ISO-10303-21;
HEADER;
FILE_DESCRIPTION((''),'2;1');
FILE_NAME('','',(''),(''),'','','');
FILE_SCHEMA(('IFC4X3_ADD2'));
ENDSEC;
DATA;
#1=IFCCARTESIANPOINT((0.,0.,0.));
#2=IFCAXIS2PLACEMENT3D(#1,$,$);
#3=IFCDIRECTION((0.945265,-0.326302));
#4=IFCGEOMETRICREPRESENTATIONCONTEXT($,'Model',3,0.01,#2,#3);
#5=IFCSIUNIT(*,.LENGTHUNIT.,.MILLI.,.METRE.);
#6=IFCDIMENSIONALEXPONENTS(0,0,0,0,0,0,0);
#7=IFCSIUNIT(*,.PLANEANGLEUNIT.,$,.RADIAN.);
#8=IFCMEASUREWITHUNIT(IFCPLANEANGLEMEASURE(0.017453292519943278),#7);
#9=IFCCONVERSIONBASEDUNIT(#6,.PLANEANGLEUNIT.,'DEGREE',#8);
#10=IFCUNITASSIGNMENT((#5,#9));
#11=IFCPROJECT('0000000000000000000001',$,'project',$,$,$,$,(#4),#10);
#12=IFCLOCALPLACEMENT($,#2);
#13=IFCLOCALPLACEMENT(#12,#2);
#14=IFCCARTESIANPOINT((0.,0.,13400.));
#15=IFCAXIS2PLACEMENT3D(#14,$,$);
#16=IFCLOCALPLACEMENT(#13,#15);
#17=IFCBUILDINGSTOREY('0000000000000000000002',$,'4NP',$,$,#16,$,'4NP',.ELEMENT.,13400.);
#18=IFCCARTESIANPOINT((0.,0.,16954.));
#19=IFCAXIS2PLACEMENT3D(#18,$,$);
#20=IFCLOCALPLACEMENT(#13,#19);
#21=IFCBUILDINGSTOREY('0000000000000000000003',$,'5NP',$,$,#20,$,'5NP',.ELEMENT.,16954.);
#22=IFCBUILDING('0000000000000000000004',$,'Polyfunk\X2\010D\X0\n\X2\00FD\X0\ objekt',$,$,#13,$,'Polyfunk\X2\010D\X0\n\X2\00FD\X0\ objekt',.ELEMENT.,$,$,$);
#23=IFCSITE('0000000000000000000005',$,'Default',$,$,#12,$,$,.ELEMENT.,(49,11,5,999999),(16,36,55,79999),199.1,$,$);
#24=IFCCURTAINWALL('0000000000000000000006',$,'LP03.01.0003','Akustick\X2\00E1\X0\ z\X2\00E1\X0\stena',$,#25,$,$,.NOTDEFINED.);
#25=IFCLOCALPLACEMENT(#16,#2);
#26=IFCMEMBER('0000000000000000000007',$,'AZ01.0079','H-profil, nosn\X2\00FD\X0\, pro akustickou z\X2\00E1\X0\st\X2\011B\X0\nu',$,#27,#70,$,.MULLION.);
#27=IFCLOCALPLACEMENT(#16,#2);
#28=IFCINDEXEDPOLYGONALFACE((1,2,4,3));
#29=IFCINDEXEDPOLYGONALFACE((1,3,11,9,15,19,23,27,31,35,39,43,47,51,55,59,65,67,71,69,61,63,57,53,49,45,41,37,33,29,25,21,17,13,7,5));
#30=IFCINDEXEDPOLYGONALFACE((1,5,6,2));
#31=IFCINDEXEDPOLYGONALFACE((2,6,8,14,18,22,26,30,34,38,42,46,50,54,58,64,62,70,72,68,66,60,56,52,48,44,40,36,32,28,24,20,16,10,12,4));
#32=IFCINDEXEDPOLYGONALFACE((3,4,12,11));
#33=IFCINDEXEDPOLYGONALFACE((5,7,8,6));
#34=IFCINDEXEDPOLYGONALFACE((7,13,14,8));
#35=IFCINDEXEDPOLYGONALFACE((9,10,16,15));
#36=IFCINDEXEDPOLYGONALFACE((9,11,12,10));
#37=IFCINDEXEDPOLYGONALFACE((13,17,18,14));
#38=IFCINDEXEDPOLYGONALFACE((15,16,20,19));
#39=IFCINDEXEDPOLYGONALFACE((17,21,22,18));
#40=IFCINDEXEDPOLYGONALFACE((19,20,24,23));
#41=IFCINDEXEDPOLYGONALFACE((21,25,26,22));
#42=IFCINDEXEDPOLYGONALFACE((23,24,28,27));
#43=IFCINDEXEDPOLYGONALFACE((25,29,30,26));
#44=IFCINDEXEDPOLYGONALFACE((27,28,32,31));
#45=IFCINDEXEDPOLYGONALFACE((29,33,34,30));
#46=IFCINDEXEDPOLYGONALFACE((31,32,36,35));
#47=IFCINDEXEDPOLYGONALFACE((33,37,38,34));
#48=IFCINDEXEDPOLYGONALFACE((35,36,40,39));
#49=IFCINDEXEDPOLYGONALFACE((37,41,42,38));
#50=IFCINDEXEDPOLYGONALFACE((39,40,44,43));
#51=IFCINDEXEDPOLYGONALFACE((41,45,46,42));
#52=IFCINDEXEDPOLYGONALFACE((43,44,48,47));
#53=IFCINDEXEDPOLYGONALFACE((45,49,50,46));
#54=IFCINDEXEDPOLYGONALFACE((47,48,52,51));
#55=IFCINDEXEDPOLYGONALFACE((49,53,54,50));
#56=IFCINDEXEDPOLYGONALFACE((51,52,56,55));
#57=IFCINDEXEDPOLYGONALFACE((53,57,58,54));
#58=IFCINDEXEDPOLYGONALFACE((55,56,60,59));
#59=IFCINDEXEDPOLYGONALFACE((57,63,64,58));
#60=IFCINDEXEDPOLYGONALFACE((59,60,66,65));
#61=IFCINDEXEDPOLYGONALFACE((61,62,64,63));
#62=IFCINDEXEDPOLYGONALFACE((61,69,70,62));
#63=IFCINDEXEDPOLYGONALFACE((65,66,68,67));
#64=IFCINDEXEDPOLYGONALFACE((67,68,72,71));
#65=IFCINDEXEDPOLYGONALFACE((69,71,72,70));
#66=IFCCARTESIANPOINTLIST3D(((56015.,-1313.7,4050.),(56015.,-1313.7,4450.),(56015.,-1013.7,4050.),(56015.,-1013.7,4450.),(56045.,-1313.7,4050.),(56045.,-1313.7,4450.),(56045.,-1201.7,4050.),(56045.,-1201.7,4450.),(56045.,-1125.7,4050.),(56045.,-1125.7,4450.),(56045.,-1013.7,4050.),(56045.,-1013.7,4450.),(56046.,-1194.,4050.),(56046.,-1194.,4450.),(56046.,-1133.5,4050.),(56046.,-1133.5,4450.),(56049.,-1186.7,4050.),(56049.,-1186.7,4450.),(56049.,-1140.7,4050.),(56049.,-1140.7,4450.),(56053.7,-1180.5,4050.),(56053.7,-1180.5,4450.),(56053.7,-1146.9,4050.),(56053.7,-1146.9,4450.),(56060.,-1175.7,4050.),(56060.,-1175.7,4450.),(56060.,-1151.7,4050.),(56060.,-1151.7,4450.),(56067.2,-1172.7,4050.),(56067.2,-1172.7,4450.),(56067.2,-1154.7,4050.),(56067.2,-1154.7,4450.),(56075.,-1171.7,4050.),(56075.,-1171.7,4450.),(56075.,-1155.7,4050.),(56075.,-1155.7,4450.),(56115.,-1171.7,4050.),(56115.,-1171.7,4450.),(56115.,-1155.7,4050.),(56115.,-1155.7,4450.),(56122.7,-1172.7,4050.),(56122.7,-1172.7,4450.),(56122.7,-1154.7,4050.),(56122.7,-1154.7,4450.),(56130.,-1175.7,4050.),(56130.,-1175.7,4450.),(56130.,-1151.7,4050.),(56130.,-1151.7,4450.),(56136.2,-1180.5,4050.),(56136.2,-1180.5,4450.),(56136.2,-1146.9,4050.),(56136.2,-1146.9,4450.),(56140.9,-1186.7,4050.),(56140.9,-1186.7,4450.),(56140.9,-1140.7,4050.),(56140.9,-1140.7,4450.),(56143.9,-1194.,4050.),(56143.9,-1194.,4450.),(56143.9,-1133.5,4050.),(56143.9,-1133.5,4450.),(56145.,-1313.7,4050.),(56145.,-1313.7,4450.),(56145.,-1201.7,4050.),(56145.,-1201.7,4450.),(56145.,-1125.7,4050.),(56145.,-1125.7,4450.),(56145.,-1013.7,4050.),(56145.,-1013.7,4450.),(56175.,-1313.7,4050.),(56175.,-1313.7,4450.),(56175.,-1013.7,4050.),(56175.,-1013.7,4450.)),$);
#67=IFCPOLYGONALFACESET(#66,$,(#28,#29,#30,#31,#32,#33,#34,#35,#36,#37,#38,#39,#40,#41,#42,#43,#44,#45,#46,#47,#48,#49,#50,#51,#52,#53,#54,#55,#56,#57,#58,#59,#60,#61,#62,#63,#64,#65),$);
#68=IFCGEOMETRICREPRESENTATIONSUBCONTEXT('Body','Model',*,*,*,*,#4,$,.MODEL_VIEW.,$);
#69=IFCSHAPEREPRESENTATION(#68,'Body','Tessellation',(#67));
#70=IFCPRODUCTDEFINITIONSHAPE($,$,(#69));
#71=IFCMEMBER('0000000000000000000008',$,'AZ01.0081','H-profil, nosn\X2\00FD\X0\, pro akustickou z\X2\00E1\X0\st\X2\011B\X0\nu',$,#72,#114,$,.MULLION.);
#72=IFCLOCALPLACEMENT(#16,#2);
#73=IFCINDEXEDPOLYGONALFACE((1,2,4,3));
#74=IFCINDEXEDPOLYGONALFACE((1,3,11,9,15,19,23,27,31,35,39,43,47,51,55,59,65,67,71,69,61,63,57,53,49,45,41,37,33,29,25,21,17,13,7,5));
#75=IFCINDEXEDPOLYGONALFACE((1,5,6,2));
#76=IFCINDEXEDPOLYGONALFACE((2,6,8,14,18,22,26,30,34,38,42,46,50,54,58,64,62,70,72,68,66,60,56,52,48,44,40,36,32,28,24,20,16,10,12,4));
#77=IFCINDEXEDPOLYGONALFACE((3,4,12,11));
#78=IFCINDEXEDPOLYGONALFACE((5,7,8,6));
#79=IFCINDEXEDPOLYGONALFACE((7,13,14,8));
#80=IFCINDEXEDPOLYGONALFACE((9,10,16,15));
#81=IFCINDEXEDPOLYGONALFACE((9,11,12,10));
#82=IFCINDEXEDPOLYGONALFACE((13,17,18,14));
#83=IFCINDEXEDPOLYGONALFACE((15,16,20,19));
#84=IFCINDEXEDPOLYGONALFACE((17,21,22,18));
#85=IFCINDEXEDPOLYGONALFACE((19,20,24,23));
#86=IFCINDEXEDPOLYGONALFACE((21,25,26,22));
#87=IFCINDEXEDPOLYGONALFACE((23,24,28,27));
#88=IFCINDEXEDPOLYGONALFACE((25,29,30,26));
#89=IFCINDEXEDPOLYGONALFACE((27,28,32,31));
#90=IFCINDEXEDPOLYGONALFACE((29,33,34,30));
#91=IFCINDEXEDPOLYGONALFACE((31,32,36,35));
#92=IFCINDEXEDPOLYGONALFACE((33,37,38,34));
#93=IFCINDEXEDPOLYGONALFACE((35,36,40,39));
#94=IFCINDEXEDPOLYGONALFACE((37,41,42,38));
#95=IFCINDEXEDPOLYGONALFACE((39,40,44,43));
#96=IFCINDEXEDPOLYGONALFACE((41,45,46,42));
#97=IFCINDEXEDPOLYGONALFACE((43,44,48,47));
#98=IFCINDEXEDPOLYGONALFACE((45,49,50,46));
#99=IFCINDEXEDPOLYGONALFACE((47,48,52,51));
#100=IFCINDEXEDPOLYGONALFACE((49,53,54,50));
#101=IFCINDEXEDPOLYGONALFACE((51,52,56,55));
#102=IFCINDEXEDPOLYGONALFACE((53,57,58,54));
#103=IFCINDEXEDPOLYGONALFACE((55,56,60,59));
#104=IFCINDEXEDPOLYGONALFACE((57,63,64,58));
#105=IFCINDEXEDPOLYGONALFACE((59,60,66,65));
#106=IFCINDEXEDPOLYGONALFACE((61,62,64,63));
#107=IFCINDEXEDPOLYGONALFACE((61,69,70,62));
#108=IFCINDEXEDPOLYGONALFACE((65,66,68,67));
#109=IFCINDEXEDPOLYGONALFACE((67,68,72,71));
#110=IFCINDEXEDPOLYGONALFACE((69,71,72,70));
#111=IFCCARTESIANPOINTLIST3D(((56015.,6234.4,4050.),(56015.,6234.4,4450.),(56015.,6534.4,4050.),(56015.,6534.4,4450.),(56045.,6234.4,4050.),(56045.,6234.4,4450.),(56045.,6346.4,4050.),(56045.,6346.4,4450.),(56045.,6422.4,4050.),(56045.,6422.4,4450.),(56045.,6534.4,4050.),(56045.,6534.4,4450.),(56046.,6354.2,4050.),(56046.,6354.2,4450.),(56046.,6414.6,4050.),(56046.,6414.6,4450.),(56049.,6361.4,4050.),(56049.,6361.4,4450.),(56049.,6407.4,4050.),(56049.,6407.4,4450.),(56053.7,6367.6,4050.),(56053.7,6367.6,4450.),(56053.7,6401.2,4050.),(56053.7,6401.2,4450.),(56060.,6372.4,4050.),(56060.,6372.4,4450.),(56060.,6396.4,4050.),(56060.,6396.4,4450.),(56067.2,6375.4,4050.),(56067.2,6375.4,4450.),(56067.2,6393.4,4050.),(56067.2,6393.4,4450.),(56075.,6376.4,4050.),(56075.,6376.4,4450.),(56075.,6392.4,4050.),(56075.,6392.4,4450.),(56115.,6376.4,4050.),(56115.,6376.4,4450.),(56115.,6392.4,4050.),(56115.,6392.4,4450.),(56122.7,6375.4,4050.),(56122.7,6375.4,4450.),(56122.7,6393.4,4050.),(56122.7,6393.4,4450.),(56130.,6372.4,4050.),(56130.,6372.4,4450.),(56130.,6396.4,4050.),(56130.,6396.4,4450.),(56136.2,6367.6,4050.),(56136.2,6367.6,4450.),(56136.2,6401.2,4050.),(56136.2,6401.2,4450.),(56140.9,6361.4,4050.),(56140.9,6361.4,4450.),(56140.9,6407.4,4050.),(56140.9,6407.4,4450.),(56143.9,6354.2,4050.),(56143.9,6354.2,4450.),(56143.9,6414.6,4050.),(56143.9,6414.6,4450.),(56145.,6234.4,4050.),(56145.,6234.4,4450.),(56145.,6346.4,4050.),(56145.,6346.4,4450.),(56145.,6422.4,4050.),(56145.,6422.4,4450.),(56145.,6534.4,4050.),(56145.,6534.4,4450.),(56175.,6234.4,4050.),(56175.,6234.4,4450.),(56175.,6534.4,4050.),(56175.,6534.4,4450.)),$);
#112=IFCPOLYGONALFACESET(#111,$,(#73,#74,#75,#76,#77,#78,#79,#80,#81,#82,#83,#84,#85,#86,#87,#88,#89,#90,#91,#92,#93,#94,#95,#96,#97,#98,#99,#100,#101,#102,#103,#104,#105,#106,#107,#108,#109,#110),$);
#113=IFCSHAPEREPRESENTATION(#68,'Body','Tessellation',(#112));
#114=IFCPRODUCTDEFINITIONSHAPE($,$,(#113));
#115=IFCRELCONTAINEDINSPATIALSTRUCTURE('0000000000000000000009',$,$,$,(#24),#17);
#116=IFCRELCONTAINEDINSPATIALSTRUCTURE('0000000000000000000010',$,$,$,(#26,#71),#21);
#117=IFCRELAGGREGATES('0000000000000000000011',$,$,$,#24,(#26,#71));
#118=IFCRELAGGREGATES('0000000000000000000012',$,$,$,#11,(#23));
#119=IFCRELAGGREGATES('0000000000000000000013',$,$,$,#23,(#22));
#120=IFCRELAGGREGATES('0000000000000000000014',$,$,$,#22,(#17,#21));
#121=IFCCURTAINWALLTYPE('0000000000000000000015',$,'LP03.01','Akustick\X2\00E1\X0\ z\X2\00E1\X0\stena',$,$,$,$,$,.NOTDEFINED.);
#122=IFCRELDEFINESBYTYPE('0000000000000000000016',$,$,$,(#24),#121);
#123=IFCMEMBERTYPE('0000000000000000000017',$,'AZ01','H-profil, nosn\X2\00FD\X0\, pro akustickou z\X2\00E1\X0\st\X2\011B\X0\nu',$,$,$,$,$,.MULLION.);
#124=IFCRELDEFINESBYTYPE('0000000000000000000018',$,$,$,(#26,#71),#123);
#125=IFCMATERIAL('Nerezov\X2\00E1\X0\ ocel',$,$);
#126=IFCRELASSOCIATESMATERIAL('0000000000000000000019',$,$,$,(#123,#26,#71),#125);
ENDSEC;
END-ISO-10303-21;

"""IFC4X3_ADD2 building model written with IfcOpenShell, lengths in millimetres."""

from ifc_helpers import new_model, entity, si_unit, converted_unit, direction, frame, frame_2d, origin, place, context, subcontext, project, spatial, polyline, circle_curve, parameter, trimmed, segment, composite_curve, outline, extrude, source, transform, mapped, material, material_profile, profile_set, profile_usage, type_object, element, aggregate, save


model = new_model("IFC4X3_ADD2")

# Units and contexts
model_context = context("Model", 3, precision=0.01, world=origin(), true_north=direction((0.945265, -0.326302)))
body_context = subcontext(model_context, "Body", "Model", "MODEL_VIEW")
ifc_project = project(units=[si_unit("LENGTHUNIT", "METRE", prefix="MILLI"), converted_unit("PLANEANGLEUNIT", "DEGREE", entity("IfcPlaneAngleMeasure", 0.017453292519943278), si_unit("PLANEANGLEUNIT", "RADIAN"), dimensions=[0, 0, 0, 0, 0, 0, 0])], contexts=[model_context])

# Site, building, storey
site_placement = place(None, origin())
site = spatial("IfcSite", under=ifc_project, at=site_placement, Name="Default", CompositionType="ELEMENT", RefLatitude=(49, 11, 5, 999999), RefLongitude=(16, 36, 55, 79999), RefElevation=199.1)
building_placement = place(site_placement, origin())
building = spatial("IfcBuilding", under=site, at=building_placement, Name="Polyfunkčný objekt", LongName="Polyfunkčný objekt", CompositionType="ELEMENT")
storey_1_placement = place(building_placement, frame((0.0, 0.0, 13400.0)))
storey_1 = spatial("IfcBuildingStorey", under=building, at=storey_1_placement, Name="4NP", LongName="4NP", CompositionType="ELEMENT", Elevation=13400.0)

# Shared definitions
curtain_wall_type = type_object("IfcCurtainWallType", Name="LP03.01", Description="Akustická zástena", PredefinedType="NOTDEFINED")

# Shared definitions
storey_2_placement = place(building_placement, frame((0.0, 0.0, 16954.0)))
storey_2 = spatial("IfcBuildingStorey", under=building, at=storey_2_placement, Name="5NP", LongName="5NP", CompositionType="ELEMENT", Elevation=16954.0)

# Shared definitions
ifc_material_1 = material(Name="Nerezová ocel")
ifc_material_profile = material_profile(ifc_material_1, outline(composite_curve([segment(polyline([(50.0, -150.0), (80.0, -150.0)]), True, "CONTINUOUS"), segment(polyline([(80.0, -150.0), (80.0, 150.0)]), True, "CONTINUOUS"), segment(polyline([(80.0, 150.0), (50.0, 150.0)]), True, "CONTINUOUS"), segment(polyline([(50.0, 150.0), (50.0, 38.0)]), True, "CONTINUOUS"), segment(trimmed(circle_curve(frame_2d((20.0, 38.0), x_axis=(0.0, 1.0)), 30.0), [parameter(180.0)], [parameter(270.0)], True, "PARAMETER"), False, "CONTINUOUS"), segment(polyline([(20.0, 8.0), (-20.0, 8.0)]), True, "CONTINUOUS"), segment(trimmed(circle_curve(frame_2d((-20.0, 38.0), x_axis=(0.0, 1.0)), 30.0), [parameter(90.0)], [parameter(180.0)], True, "PARAMETER"), False, "CONTINUOUS"), segment(polyline([(-50.0, 38.0), (-50.0, 150.0)]), True, "CONTINUOUS"), segment(polyline([(-50.0, 150.0), (-80.0, 150.0)]), True, "CONTINUOUS"), segment(polyline([(-80.0, 150.0), (-80.0, -150.0)]), True, "CONTINUOUS"), segment(polyline([(-80.0, -150.0), (-50.0, -150.0)]), True, "CONTINUOUS"), segment(polyline([(-50.0, -150.0), (-50.0, -38.0)]), True, "CONTINUOUS"), segment(trimmed(circle_curve(frame_2d((-20.0, -38.0), x_axis=(0.0, 1.0)), 30.0), [parameter(0.0)], [parameter(90.0)], True, "PARAMETER"), False, "CONTINUOUS"), segment(polyline([(-20.0, -8.0), (20.0, -8.0)]), True, "CONTINUOUS"), segment(trimmed(circle_curve(frame_2d((20.0, -38.0), x_axis=(0.0, 1.0)), 30.0), [parameter(270.0)], [parameter(0.0)], True, "PARAMETER"), False, "CONTINUOUS"), segment(polyline([(50.0, -38.0), (50.0, -150.0)]), True, "CONTINUOUS")], self_intersect=False)), Name="Profil zástena")
ifc_profile_set = profile_set([ifc_material_profile], Name="Profil zástena")
ifc_profile_usage = profile_usage(ifc_profile_set)
member_type = type_object("IfcMemberType", Name="AZ01", Description="H-profil, nosný, pro akustickou zástěnu", PredefinedType="MULLION", material=ifc_profile_set)

# Curtain wall, members
curtain_wall_1_placement = place(storey_1_placement, frame((0.0, 0.0, -13400.0)))
curtain_wall_1 = element("IfcCurtainWall", 1, at=curtain_wall_1_placement, inside=storey_1, type_object=curtain_wall_type, Name="LP03.01.0003", Description="Akustická zástena", PredefinedType="NOTDEFINED")
shared_shape_1 = source(origin(), body_context, "Body", "SweptSolid", [
    extrude(outline(composite_curve([segment(polyline([(50.0, -150.0), (80.0, -150.0)]), True, "CONTINUOUS"), segment(polyline([(80.0, -150.0), (80.0, 150.0)]), True, "CONTINUOUS"), segment(polyline([(80.0, 150.0), (50.0, 150.0)]), True, "CONTINUOUS"), segment(polyline([(50.0, 150.0), (50.0, 38.0)]), True, "CONTINUOUS"), segment(trimmed(circle_curve(frame_2d((20.0, 38.0), x_axis=(0.0, 1.0)), 30.0), [parameter(180.0)], [parameter(270.0)], True, "PARAMETER"), False, "CONTINUOUS"), segment(polyline([(20.0, 8.0), (-20.0, 8.0)]), True, "CONTINUOUS"), segment(trimmed(circle_curve(frame_2d((-20.0, 38.0), x_axis=(0.0, 1.0)), 30.0), [parameter(90.0)], [parameter(180.0)], True, "PARAMETER"), False, "CONTINUOUS"), segment(polyline([(-50.0, 38.0), (-50.0, 150.0)]), True, "CONTINUOUS"), segment(polyline([(-50.0, 150.0), (-80.0, 150.0)]), True, "CONTINUOUS"), segment(polyline([(-80.0, 150.0), (-80.0, -150.0)]), True, "CONTINUOUS"), segment(polyline([(-80.0, -150.0), (-50.0, -150.0)]), True, "CONTINUOUS"), segment(polyline([(-50.0, -150.0), (-50.0, -38.0)]), True, "CONTINUOUS"), segment(trimmed(circle_curve(frame_2d((-20.0, -38.0), x_axis=(0.0, 1.0)), 30.0), [parameter(0.0)], [parameter(90.0)], True, "PARAMETER"), False, "CONTINUOUS"), segment(polyline([(-20.0, -8.0), (20.0, -8.0)]), True, "CONTINUOUS"), segment(trimmed(circle_curve(frame_2d((20.0, -38.0), x_axis=(0.0, 1.0)), 30.0), [parameter(270.0)], [parameter(0.0)], True, "PARAMETER"), False, "CONTINUOUS"), segment(polyline([(50.0, -38.0), (50.0, -150.0)]), True, "CONTINUOUS")], self_intersect=False)), frame((-150.0, 0.0, -400.0), z_axis=(0.0, 0.0, 1.0), x_axis=(0.0, 1.0, 0.0)), (0.0, 0.0, 1.0), 400.0),
])
member_1_placement = place(curtain_wall_1_placement, frame((56095.0, -1313.7, 17850.0), z_axis=(0.0, 0.0, 1.0), x_axis=(0.0, -1.0, 0.0)))
member_1 = element("IfcMember", 2, at=member_1_placement, inside=storey_2, type_object=member_type, material=ifc_profile_usage, Name="AZ01.0079", Description="H-profil, nosný, pro akustickou zástěnu", PredefinedType="MULLION", context=body_context, shape_type="MappedRepresentation", body=[
    mapped(shared_shape_1, transform((0.0, 0.0, 0.0), scale=1.0)),
])
shared_shape_2 = source(origin(), body_context, "Body", "SweptSolid", [
    extrude(outline(composite_curve([segment(polyline([(-150.0, -50.0), (-150.0, -80.0)]), True, "CONTINUOUS"), segment(polyline([(-150.0, -80.0), (150.0, -80.0)]), True, "CONTINUOUS"), segment(polyline([(150.0, -80.0), (150.0, -50.0)]), True, "CONTINUOUS"), segment(polyline([(150.0, -50.0), (38.0, -50.0)]), True, "CONTINUOUS"), segment(trimmed(circle_curve(frame_2d((38.0, -20.0), x_axis=(1.0, 0.0)), 30.0), [parameter(180.0)], [parameter(270.0)], True, "PARAMETER"), False, "CONTINUOUS"), segment(polyline([(8.0, -20.0), (8.0, 20.0)]), True, "CONTINUOUS"), segment(trimmed(circle_curve(frame_2d((38.0, 20.0), x_axis=(1.0, 0.0)), 30.0), [parameter(90.0)], [parameter(180.0)], True, "PARAMETER"), False, "CONTINUOUS"), segment(polyline([(38.0, 50.0), (150.0, 50.0)]), True, "CONTINUOUS"), segment(polyline([(150.0, 50.0), (150.0, 80.0)]), True, "CONTINUOUS"), segment(polyline([(150.0, 80.0), (-150.0, 80.0)]), True, "CONTINUOUS"), segment(polyline([(-150.0, 80.0), (-150.0, 50.0)]), True, "CONTINUOUS"), segment(polyline([(-150.0, 50.0), (-38.0, 50.0)]), True, "CONTINUOUS"), segment(trimmed(circle_curve(frame_2d((-38.0, 20.0), x_axis=(1.0, 0.0)), 30.0), [parameter(0.0)], [parameter(90.0)], True, "PARAMETER"), False, "CONTINUOUS"), segment(polyline([(-8.0, 20.0), (-8.0, -20.0)]), True, "CONTINUOUS"), segment(trimmed(circle_curve(frame_2d((-38.0, -20.0), x_axis=(1.0, 0.0)), 30.0), [parameter(270.0)], [parameter(0.0)], True, "PARAMETER"), False, "CONTINUOUS"), segment(polyline([(-38.0, -50.0), (-150.0, -50.0)]), True, "CONTINUOUS")], self_intersect=False)), frame((-150.0, 0.0, -400.0), z_axis=(0.0, 0.0, -1.0), x_axis=(1.0, 0.0, 0.0)), (0.0, 0.0, -1.0), 400.0),
])
member_2_placement = place(curtain_wall_1_placement, frame((56095.0, 6534.4, 17450.0), z_axis=(0.0, 0.0, -1.0), x_axis=(0.0, 1.0, 0.0)))
member_2 = element("IfcMember", 3, at=member_2_placement, inside=storey_2, type_object=member_type, material=ifc_profile_usage, Name="AZ01.0081", Description="H-profil, nosný, pro akustickou zástěnu", PredefinedType="MULLION", context=body_context, shape_type="MappedRepresentation", body=[
    mapped(shared_shape_2, transform((0.0, 0.0, 0.0), scale=1.0)),
])

aggregate(curtain_wall_1, [member_1, member_2])

save(model, "model.ifc")
